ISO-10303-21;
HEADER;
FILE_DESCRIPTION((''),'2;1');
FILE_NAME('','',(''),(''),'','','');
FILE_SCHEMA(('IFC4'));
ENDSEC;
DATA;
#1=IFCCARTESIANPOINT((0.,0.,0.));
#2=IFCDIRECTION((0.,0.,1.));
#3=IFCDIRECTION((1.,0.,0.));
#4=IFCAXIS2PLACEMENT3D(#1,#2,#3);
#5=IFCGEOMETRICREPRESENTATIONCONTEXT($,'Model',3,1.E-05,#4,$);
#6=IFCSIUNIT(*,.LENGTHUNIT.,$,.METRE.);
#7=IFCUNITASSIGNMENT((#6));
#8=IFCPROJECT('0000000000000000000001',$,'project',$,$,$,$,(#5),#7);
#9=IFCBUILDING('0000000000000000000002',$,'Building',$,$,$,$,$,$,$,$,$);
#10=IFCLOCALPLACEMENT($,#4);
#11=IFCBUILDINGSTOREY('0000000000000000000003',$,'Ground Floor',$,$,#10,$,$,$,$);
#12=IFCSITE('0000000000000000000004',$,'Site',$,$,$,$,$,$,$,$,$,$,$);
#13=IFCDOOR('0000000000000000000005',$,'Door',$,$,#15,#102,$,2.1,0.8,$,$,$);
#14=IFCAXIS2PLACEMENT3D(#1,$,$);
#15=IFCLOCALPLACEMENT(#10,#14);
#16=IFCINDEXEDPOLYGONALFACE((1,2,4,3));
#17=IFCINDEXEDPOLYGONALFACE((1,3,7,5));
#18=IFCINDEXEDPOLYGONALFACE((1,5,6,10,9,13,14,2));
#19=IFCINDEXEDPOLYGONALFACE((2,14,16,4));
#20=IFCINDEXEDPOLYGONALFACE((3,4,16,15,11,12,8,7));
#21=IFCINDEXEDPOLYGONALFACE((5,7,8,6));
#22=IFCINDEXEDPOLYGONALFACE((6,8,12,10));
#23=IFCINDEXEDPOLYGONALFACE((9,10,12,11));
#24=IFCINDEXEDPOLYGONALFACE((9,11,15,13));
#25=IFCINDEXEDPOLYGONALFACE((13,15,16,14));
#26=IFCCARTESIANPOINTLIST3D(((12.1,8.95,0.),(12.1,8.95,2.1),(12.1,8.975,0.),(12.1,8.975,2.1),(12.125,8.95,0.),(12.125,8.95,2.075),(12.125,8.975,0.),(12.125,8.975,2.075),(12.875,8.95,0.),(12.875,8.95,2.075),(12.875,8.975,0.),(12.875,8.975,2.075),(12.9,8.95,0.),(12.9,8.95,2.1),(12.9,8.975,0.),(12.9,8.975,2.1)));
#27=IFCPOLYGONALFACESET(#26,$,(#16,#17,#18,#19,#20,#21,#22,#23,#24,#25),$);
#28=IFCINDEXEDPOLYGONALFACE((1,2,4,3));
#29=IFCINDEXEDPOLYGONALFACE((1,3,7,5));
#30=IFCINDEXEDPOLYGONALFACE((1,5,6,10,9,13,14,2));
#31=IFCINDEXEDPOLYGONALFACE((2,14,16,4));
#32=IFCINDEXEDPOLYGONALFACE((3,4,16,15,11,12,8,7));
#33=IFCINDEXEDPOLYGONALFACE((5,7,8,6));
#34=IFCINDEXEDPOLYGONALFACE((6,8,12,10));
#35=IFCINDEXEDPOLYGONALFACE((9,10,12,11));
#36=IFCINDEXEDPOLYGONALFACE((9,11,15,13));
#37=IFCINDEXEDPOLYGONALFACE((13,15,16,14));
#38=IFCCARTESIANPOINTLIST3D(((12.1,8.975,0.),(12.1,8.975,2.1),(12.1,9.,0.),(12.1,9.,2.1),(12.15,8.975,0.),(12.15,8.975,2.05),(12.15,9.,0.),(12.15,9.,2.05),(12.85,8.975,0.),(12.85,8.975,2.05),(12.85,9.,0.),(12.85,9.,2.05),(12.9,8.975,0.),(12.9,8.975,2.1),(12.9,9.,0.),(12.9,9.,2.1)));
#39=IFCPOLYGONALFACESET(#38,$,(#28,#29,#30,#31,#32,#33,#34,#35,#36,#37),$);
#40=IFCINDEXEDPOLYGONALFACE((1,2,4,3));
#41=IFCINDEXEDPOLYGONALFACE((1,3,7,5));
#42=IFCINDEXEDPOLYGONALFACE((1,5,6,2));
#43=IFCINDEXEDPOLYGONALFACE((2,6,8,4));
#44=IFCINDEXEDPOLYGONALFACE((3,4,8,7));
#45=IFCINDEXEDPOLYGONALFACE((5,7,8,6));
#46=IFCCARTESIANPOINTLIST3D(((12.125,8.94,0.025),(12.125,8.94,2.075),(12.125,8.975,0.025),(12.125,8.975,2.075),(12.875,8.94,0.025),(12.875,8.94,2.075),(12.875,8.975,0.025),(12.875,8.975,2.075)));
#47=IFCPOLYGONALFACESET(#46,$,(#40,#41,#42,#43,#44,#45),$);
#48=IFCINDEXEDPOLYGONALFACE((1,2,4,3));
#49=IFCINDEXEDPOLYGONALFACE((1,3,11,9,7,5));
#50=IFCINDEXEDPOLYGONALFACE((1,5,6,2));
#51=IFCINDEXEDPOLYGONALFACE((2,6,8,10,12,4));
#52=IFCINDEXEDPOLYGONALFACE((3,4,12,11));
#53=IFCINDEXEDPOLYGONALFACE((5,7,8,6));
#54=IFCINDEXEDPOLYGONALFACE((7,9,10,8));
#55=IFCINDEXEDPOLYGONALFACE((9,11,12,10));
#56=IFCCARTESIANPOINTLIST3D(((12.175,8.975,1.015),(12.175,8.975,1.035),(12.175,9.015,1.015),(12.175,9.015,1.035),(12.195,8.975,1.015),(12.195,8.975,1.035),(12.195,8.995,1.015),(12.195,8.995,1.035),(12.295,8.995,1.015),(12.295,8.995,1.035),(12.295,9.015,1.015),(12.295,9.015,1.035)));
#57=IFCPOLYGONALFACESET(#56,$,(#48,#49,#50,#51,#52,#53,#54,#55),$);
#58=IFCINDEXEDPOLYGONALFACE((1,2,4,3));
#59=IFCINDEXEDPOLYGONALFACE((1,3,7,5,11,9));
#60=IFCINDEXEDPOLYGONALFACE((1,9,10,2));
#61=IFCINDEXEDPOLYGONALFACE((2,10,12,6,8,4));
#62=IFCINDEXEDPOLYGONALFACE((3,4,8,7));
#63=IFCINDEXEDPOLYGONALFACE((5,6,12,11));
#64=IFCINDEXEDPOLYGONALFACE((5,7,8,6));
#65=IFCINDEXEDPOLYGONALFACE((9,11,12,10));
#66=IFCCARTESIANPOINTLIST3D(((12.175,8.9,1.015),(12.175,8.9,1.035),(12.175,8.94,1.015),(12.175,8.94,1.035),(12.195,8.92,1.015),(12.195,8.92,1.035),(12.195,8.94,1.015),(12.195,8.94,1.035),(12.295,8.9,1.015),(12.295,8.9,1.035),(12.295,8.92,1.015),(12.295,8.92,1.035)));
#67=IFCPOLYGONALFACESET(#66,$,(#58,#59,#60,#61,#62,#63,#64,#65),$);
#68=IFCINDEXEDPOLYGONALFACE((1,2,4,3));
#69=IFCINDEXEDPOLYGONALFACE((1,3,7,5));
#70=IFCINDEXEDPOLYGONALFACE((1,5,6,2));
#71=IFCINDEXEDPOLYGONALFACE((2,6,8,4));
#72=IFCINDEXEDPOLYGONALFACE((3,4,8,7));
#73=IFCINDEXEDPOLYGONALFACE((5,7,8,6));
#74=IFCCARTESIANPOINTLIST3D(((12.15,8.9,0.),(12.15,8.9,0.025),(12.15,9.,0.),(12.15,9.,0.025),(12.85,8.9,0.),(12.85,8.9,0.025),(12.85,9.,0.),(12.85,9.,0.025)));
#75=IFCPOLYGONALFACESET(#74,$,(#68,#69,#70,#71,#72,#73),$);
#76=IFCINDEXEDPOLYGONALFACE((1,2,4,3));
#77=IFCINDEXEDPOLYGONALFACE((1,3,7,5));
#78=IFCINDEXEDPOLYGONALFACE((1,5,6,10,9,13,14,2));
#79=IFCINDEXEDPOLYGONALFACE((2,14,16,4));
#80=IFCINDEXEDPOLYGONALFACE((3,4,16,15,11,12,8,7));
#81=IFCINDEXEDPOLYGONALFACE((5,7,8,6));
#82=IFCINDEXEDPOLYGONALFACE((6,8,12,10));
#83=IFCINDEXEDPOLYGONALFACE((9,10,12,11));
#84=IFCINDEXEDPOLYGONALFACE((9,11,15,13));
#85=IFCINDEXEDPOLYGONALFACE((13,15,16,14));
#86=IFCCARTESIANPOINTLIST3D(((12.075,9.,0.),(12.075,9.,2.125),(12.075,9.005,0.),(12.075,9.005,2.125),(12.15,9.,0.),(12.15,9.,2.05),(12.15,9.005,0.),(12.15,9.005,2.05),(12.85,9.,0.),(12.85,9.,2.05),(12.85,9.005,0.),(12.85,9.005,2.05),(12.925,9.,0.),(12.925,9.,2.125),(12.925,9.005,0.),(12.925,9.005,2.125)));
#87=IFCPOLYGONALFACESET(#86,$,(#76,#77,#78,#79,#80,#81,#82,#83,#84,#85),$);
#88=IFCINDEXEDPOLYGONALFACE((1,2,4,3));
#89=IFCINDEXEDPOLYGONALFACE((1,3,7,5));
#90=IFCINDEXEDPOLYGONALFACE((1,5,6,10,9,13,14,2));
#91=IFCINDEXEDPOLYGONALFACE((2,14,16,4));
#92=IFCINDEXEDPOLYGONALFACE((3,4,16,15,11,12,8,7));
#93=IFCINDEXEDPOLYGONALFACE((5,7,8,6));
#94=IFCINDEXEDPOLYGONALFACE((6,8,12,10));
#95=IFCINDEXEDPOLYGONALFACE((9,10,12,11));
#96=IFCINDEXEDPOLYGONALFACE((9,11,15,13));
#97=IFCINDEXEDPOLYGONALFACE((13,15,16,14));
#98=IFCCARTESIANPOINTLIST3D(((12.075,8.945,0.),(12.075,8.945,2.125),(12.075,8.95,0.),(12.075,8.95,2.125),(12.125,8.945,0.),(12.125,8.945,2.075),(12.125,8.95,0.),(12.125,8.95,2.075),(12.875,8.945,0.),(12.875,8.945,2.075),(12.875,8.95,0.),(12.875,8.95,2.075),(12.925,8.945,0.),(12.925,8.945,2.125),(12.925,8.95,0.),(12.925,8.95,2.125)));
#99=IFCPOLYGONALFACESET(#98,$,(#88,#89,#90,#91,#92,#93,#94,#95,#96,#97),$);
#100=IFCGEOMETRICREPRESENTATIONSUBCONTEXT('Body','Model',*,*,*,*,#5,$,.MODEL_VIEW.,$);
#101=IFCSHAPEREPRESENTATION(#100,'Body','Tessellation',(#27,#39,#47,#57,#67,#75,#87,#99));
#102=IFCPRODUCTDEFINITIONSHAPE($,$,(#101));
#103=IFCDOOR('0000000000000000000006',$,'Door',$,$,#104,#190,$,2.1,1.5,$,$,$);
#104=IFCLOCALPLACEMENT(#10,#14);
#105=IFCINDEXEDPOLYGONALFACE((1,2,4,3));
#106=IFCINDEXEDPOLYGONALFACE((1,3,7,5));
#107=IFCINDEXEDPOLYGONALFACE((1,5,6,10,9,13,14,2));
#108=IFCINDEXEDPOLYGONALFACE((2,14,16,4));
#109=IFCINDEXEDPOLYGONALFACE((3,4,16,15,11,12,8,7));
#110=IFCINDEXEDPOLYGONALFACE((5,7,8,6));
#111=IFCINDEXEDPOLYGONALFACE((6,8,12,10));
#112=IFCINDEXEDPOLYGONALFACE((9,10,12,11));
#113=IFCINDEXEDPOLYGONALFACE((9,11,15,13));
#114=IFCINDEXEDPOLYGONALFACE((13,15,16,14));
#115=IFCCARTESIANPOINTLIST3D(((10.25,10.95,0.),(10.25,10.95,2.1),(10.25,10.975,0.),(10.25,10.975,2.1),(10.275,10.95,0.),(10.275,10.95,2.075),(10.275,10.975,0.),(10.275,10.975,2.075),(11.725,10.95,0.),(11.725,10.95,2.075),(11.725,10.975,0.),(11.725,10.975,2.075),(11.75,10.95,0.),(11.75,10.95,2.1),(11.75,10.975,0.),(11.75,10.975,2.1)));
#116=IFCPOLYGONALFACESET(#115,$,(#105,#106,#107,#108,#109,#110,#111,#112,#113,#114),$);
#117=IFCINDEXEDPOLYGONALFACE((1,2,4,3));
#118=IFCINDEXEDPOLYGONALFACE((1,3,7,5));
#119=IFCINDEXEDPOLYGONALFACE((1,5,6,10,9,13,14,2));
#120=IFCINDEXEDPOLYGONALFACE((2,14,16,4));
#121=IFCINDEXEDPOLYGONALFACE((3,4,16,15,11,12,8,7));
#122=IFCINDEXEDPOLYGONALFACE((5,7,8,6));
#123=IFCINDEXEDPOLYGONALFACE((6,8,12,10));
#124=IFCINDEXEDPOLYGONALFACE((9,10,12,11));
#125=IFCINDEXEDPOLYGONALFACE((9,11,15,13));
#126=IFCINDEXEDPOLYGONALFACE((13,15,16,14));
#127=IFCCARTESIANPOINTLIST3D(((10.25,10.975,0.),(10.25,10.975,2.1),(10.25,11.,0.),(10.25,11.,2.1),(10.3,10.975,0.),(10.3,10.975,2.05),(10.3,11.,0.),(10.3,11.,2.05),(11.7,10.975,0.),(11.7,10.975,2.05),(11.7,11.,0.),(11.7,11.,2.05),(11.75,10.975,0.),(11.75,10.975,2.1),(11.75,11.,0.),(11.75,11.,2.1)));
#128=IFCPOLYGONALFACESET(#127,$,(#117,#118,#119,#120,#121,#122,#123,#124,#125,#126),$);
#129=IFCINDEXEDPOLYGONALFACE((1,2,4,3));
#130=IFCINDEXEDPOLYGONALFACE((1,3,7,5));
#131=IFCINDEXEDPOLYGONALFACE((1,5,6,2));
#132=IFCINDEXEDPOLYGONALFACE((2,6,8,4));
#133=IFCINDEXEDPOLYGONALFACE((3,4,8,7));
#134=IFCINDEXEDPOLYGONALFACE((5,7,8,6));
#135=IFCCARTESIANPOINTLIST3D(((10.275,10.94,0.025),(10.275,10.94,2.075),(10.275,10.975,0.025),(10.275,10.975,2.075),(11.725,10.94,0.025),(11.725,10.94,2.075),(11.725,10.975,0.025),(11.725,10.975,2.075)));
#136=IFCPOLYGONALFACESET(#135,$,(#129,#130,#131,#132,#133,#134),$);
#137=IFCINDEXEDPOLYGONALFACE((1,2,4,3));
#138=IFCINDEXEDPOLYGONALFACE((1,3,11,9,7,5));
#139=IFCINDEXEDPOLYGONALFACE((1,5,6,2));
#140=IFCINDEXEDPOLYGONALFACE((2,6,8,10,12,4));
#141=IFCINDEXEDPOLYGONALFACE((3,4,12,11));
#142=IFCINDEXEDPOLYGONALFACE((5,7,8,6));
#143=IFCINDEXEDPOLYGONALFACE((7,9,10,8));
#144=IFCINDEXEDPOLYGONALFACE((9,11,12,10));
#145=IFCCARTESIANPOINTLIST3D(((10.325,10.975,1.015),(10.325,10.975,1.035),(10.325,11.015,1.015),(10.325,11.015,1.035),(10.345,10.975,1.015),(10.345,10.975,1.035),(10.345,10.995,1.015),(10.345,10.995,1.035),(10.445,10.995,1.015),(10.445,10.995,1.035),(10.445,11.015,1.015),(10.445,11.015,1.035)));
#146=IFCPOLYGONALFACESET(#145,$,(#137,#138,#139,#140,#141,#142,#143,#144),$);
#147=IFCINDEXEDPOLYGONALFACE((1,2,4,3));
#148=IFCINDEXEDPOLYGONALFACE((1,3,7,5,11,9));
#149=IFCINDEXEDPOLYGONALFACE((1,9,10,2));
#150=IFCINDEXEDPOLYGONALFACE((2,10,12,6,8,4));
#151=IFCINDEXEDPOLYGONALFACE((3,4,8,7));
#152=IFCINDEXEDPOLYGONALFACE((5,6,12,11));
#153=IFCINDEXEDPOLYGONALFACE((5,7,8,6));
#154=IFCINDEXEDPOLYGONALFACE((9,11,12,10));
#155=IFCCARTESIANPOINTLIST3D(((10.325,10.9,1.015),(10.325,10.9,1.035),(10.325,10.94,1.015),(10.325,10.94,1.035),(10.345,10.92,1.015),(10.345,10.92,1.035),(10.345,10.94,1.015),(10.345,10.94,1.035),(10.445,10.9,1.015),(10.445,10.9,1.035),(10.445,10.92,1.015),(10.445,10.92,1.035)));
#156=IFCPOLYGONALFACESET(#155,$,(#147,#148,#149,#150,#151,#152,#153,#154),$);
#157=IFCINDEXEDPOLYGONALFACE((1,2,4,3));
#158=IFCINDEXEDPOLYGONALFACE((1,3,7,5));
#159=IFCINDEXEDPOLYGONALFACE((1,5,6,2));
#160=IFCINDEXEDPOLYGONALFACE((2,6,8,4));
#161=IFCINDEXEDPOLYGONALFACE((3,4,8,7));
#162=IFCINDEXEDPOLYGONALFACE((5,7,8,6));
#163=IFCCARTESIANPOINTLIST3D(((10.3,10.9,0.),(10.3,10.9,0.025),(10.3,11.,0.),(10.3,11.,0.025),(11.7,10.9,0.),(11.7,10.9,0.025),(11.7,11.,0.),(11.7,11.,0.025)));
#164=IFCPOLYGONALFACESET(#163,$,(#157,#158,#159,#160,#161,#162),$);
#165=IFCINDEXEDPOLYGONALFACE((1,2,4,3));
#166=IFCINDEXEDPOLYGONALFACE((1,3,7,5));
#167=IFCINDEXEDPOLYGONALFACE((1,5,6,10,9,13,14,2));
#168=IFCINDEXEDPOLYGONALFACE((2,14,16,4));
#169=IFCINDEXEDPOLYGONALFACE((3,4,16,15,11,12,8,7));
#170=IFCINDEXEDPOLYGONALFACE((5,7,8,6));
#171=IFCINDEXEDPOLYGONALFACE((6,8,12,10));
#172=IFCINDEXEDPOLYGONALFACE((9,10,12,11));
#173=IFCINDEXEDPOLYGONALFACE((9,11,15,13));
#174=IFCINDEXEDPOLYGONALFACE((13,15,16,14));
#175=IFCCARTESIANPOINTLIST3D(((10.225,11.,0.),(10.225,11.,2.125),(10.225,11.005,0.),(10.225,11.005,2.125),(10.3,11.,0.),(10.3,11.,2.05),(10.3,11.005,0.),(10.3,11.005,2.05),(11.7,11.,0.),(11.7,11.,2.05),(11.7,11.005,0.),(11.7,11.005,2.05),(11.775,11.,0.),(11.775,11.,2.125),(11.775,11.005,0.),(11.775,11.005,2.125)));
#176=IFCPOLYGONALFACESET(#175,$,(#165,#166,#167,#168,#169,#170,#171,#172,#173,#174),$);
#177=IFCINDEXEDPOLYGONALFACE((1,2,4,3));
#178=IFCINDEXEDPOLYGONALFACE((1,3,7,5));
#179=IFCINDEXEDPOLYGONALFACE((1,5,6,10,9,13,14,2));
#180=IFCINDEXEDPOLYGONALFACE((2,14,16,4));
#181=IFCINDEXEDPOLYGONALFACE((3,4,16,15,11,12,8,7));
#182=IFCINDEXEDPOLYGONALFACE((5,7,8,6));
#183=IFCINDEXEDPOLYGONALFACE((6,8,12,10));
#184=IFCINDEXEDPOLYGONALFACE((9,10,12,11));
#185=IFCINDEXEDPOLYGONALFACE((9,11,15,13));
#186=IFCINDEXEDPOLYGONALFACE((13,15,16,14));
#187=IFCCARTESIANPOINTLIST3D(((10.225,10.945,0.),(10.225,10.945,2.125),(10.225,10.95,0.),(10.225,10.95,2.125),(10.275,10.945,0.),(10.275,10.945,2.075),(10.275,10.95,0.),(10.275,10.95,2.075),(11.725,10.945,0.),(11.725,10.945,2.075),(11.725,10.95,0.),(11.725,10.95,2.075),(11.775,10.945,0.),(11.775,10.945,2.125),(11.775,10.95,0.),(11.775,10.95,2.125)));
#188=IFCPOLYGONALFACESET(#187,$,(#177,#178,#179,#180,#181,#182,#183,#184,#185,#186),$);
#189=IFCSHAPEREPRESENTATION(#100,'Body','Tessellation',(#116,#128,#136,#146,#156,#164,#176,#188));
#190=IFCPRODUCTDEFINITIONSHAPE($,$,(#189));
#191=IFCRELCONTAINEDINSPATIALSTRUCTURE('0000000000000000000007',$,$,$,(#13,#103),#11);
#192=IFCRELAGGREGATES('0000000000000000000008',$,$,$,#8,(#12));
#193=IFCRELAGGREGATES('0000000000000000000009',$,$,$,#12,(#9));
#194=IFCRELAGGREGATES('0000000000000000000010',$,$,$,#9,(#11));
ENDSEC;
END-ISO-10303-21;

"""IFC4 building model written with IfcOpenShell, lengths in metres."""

from ifc_helpers import new_model, si_unit, frame, origin_with_axes, place, context, subcontext, project, spatial, line, indexed_curve, outline, extrude, element, save


model = new_model("IFC4")

# Units and contexts
model_context = context("Model", 3, precision=1e-05, world=origin_with_axes())
body_context = subcontext(model_context, "Body", "Model", "MODEL_VIEW")
ifc_project = project(units=[si_unit("LENGTHUNIT", "METRE")], contexts=[model_context])

# Site, building, storey
site = spatial("IfcSite", under=ifc_project, Name="Site")
building = spatial("IfcBuilding", under=site, Name="Building")
storey_placement = place(None, origin_with_axes())
storey = spatial("IfcBuildingStorey", under=building, at=storey_placement, Name="Ground Floor")

# Doors
door_1_placement = place(storey_placement, frame((12.9, 9.0, 0.0), z_axis=(0.0, 0.0, 1.0), x_axis=(-1.0, 0.0, 0.0)))
element("IfcDoor", 1, at=door_1_placement, inside=storey, Name="Door", OverallHeight=2.1, OverallWidth=0.8, context=body_context, shape_type="SweptSolid", body=[
    extrude(outline(indexed_curve([(0.0, 0.0), (0.0, 2.1), (0.8, 2.1), (0.8, 0.0), (0.775, 0.0), (0.775, 2.075), (0.025, 2.075), (0.025, 0.0)], segments=[line(1, 2, 3, 4, 5, 6, 7, 8, 1)])), frame((0.0, 0.025, 0.0), z_axis=(0.0, -1.0, 0.0), x_axis=(1.0, 0.0, 0.0)), (0.0, 0.0, -1.0), 0.025),
    extrude(outline(indexed_curve([(0.0, 0.0), (0.0, 2.1), (0.8, 2.1), (0.8, 0.0), (0.75, 0.0), (0.75, 2.05), (0.05, 2.05), (0.05, 0.0)], segments=[line(1, 2, 3, 4, 5, 6, 7, 8, 1)])), frame((0.0, 0.0, 0.0), z_axis=(0.0, -1.0, 0.0), x_axis=(1.0, 0.0, 0.0)), (0.0, 0.0, -1.0), 0.025),
    extrude(outline(indexed_curve([(0.0, 0.0), (0.75, 0.0), (0.75, 0.035), (0.0, 0.035)], segments=[line(1, 2, 3, 4, 1)])), frame((0.025, 0.025, 0.025), z_axis=(0.0, 0.0, 1.0), x_axis=(1.0, 0.0, 0.0)), (0.0, 0.0, 1.0), 2.05),
    extrude(outline(indexed_curve([(0.0, 0.0), (0.0, -0.04), (-0.12, -0.04), (-0.12, -0.02), (-0.02, -0.02), (-0.02, 0.0)], segments=[line(1, 2, 3, 4, 5, 6, 1)])), frame((0.725, 0.025, 1.015), z_axis=(0.0, 0.0, 1.0), x_axis=(1.0, 0.0, 0.0)), (0.0, 0.0, 1.0), 0.02),
    extrude(outline(indexed_curve([(0.0, 0.0), (0.0, 0.04), (-0.12, 0.04), (-0.12, 0.02), (-0.02, 0.02), (-0.02, 0.0)], segments=[line(1, 2, 3, 4, 5, 6, 1)])), frame((0.725, 0.06, 1.015), z_axis=(0.0, 0.0, 1.0), x_axis=(1.0, 0.0, 0.0)), (0.0, 0.0, 1.0), 0.02),
    extrude(outline(indexed_curve([(0.0, 0.0), (0.7, 0.0), (0.7, 0.1), (0.0, 0.1)], segments=[line(1, 2, 3, 4, 1)])), frame((0.05, 0.0, 0.0), z_axis=(0.0, 0.0, 1.0), x_axis=(1.0, 0.0, 0.0)), (0.0, 0.0, 1.0), 0.025),
    extrude(outline(indexed_curve([(0.0, 0.0), (0.0, 2.125), (0.85, 2.125), (0.85, 0.0), (0.775, 0.0), (0.775, 2.05), (0.075, 2.05), (0.075, 0.0)], segments=[line(1, 2, 3, 4, 5, 6, 7, 8, 1)])), frame((-0.025, -0.005, 0.0), z_axis=(0.0, -1.0, 0.0), x_axis=(1.0, 0.0, 0.0)), (0.0, 0.0, -1.0), 0.005),
    extrude(outline(indexed_curve([(0.0, 0.0), (0.0, 2.125), (0.85, 2.125), (0.85, 0.0), (0.8, 0.0), (0.8, 2.075), (0.05, 2.075), (0.05, 0.0)], segments=[line(1, 2, 3, 4, 5, 6, 7, 8, 1)])), frame((-0.025, 0.05, 0.0), z_axis=(0.0, -1.0, 0.0), x_axis=(1.0, 0.0, 0.0)), (0.0, 0.0, -1.0), 0.005),
])
door_2_placement = place(storey_placement, frame((11.75, 11.0, 0.0), z_axis=(0.0, 0.0, 1.0), x_axis=(-1.0, 0.0, 0.0)))
element("IfcDoor", 2, at=door_2_placement, inside=storey, Name="Door", OverallHeight=2.1, OverallWidth=1.5, context=body_context, shape_type="SweptSolid", body=[
    extrude(outline(indexed_curve([(0.0, 0.0), (0.0, 2.1), (1.5, 2.1), (1.5, 0.0), (1.475, 0.0), (1.475, 2.075), (0.025, 2.075), (0.025, 0.0)], segments=[line(1, 2, 3, 4, 5, 6, 7, 8, 1)])), frame((0.0, 0.025, 0.0), z_axis=(0.0, -1.0, 0.0), x_axis=(1.0, 0.0, 0.0)), (0.0, 0.0, -1.0), 0.025),
    extrude(outline(indexed_curve([(0.0, 0.0), (0.0, 2.1), (1.5, 2.1), (1.5, 0.0), (1.45, 0.0), (1.45, 2.05), (0.05, 2.05), (0.05, 0.0)], segments=[line(1, 2, 3, 4, 5, 6, 7, 8, 1)])), frame((0.0, 0.0, 0.0), z_axis=(0.0, -1.0, 0.0), x_axis=(1.0, 0.0, 0.0)), (0.0, 0.0, -1.0), 0.025),
    extrude(outline(indexed_curve([(0.0, 0.0), (1.45, 0.0), (1.45, 0.035), (0.0, 0.035)], segments=[line(1, 2, 3, 4, 1)])), frame((0.025, 0.025, 0.025), z_axis=(0.0, 0.0, 1.0), x_axis=(1.0, 0.0, 0.0)), (0.0, 0.0, 1.0), 2.05),
    extrude(outline(indexed_curve([(0.0, 0.0), (0.0, -0.04), (-0.12, -0.04), (-0.12, -0.02), (-0.02, -0.02), (-0.02, 0.0)], segments=[line(1, 2, 3, 4, 5, 6, 1)])), frame((1.425, 0.025, 1.015), z_axis=(0.0, 0.0, 1.0), x_axis=(1.0, 0.0, 0.0)), (0.0, 0.0, 1.0), 0.02),
    extrude(outline(indexed_curve([(0.0, 0.0), (0.0, 0.04), (-0.12, 0.04), (-0.12, 0.02), (-0.02, 0.02), (-0.02, 0.0)], segments=[line(1, 2, 3, 4, 5, 6, 1)])), frame((1.425, 0.06, 1.015), z_axis=(0.0, 0.0, 1.0), x_axis=(1.0, 0.0, 0.0)), (0.0, 0.0, 1.0), 0.02),
    extrude(outline(indexed_curve([(0.0, 0.0), (1.4, 0.0), (1.4, 0.1), (0.0, 0.1)], segments=[line(1, 2, 3, 4, 1)])), frame((0.05, 0.0, 0.0), z_axis=(0.0, 0.0, 1.0), x_axis=(1.0, 0.0, 0.0)), (0.0, 0.0, 1.0), 0.025),
    extrude(outline(indexed_curve([(0.0, 0.0), (0.0, 2.125), (1.55, 2.125), (1.55, 0.0), (1.475, 0.0), (1.475, 2.05), (0.075, 2.05), (0.075, 0.0)], segments=[line(1, 2, 3, 4, 5, 6, 7, 8, 1)])), frame((-0.025, -0.005, 0.0), z_axis=(0.0, -1.0, 0.0), x_axis=(1.0, 0.0, 0.0)), (0.0, 0.0, -1.0), 0.005),
    extrude(outline(indexed_curve([(0.0, 0.0), (0.0, 2.125), (1.55, 2.125), (1.55, 0.0), (1.5, 0.0), (1.5, 2.075), (0.05, 2.075), (0.05, 0.0)], segments=[line(1, 2, 3, 4, 5, 6, 7, 8, 1)])), frame((-0.025, 0.05, 0.0), z_axis=(0.0, -1.0, 0.0), x_axis=(1.0, 0.0, 0.0)), (0.0, 0.0, -1.0), 0.005),
])

save(model, "model.ifc")
